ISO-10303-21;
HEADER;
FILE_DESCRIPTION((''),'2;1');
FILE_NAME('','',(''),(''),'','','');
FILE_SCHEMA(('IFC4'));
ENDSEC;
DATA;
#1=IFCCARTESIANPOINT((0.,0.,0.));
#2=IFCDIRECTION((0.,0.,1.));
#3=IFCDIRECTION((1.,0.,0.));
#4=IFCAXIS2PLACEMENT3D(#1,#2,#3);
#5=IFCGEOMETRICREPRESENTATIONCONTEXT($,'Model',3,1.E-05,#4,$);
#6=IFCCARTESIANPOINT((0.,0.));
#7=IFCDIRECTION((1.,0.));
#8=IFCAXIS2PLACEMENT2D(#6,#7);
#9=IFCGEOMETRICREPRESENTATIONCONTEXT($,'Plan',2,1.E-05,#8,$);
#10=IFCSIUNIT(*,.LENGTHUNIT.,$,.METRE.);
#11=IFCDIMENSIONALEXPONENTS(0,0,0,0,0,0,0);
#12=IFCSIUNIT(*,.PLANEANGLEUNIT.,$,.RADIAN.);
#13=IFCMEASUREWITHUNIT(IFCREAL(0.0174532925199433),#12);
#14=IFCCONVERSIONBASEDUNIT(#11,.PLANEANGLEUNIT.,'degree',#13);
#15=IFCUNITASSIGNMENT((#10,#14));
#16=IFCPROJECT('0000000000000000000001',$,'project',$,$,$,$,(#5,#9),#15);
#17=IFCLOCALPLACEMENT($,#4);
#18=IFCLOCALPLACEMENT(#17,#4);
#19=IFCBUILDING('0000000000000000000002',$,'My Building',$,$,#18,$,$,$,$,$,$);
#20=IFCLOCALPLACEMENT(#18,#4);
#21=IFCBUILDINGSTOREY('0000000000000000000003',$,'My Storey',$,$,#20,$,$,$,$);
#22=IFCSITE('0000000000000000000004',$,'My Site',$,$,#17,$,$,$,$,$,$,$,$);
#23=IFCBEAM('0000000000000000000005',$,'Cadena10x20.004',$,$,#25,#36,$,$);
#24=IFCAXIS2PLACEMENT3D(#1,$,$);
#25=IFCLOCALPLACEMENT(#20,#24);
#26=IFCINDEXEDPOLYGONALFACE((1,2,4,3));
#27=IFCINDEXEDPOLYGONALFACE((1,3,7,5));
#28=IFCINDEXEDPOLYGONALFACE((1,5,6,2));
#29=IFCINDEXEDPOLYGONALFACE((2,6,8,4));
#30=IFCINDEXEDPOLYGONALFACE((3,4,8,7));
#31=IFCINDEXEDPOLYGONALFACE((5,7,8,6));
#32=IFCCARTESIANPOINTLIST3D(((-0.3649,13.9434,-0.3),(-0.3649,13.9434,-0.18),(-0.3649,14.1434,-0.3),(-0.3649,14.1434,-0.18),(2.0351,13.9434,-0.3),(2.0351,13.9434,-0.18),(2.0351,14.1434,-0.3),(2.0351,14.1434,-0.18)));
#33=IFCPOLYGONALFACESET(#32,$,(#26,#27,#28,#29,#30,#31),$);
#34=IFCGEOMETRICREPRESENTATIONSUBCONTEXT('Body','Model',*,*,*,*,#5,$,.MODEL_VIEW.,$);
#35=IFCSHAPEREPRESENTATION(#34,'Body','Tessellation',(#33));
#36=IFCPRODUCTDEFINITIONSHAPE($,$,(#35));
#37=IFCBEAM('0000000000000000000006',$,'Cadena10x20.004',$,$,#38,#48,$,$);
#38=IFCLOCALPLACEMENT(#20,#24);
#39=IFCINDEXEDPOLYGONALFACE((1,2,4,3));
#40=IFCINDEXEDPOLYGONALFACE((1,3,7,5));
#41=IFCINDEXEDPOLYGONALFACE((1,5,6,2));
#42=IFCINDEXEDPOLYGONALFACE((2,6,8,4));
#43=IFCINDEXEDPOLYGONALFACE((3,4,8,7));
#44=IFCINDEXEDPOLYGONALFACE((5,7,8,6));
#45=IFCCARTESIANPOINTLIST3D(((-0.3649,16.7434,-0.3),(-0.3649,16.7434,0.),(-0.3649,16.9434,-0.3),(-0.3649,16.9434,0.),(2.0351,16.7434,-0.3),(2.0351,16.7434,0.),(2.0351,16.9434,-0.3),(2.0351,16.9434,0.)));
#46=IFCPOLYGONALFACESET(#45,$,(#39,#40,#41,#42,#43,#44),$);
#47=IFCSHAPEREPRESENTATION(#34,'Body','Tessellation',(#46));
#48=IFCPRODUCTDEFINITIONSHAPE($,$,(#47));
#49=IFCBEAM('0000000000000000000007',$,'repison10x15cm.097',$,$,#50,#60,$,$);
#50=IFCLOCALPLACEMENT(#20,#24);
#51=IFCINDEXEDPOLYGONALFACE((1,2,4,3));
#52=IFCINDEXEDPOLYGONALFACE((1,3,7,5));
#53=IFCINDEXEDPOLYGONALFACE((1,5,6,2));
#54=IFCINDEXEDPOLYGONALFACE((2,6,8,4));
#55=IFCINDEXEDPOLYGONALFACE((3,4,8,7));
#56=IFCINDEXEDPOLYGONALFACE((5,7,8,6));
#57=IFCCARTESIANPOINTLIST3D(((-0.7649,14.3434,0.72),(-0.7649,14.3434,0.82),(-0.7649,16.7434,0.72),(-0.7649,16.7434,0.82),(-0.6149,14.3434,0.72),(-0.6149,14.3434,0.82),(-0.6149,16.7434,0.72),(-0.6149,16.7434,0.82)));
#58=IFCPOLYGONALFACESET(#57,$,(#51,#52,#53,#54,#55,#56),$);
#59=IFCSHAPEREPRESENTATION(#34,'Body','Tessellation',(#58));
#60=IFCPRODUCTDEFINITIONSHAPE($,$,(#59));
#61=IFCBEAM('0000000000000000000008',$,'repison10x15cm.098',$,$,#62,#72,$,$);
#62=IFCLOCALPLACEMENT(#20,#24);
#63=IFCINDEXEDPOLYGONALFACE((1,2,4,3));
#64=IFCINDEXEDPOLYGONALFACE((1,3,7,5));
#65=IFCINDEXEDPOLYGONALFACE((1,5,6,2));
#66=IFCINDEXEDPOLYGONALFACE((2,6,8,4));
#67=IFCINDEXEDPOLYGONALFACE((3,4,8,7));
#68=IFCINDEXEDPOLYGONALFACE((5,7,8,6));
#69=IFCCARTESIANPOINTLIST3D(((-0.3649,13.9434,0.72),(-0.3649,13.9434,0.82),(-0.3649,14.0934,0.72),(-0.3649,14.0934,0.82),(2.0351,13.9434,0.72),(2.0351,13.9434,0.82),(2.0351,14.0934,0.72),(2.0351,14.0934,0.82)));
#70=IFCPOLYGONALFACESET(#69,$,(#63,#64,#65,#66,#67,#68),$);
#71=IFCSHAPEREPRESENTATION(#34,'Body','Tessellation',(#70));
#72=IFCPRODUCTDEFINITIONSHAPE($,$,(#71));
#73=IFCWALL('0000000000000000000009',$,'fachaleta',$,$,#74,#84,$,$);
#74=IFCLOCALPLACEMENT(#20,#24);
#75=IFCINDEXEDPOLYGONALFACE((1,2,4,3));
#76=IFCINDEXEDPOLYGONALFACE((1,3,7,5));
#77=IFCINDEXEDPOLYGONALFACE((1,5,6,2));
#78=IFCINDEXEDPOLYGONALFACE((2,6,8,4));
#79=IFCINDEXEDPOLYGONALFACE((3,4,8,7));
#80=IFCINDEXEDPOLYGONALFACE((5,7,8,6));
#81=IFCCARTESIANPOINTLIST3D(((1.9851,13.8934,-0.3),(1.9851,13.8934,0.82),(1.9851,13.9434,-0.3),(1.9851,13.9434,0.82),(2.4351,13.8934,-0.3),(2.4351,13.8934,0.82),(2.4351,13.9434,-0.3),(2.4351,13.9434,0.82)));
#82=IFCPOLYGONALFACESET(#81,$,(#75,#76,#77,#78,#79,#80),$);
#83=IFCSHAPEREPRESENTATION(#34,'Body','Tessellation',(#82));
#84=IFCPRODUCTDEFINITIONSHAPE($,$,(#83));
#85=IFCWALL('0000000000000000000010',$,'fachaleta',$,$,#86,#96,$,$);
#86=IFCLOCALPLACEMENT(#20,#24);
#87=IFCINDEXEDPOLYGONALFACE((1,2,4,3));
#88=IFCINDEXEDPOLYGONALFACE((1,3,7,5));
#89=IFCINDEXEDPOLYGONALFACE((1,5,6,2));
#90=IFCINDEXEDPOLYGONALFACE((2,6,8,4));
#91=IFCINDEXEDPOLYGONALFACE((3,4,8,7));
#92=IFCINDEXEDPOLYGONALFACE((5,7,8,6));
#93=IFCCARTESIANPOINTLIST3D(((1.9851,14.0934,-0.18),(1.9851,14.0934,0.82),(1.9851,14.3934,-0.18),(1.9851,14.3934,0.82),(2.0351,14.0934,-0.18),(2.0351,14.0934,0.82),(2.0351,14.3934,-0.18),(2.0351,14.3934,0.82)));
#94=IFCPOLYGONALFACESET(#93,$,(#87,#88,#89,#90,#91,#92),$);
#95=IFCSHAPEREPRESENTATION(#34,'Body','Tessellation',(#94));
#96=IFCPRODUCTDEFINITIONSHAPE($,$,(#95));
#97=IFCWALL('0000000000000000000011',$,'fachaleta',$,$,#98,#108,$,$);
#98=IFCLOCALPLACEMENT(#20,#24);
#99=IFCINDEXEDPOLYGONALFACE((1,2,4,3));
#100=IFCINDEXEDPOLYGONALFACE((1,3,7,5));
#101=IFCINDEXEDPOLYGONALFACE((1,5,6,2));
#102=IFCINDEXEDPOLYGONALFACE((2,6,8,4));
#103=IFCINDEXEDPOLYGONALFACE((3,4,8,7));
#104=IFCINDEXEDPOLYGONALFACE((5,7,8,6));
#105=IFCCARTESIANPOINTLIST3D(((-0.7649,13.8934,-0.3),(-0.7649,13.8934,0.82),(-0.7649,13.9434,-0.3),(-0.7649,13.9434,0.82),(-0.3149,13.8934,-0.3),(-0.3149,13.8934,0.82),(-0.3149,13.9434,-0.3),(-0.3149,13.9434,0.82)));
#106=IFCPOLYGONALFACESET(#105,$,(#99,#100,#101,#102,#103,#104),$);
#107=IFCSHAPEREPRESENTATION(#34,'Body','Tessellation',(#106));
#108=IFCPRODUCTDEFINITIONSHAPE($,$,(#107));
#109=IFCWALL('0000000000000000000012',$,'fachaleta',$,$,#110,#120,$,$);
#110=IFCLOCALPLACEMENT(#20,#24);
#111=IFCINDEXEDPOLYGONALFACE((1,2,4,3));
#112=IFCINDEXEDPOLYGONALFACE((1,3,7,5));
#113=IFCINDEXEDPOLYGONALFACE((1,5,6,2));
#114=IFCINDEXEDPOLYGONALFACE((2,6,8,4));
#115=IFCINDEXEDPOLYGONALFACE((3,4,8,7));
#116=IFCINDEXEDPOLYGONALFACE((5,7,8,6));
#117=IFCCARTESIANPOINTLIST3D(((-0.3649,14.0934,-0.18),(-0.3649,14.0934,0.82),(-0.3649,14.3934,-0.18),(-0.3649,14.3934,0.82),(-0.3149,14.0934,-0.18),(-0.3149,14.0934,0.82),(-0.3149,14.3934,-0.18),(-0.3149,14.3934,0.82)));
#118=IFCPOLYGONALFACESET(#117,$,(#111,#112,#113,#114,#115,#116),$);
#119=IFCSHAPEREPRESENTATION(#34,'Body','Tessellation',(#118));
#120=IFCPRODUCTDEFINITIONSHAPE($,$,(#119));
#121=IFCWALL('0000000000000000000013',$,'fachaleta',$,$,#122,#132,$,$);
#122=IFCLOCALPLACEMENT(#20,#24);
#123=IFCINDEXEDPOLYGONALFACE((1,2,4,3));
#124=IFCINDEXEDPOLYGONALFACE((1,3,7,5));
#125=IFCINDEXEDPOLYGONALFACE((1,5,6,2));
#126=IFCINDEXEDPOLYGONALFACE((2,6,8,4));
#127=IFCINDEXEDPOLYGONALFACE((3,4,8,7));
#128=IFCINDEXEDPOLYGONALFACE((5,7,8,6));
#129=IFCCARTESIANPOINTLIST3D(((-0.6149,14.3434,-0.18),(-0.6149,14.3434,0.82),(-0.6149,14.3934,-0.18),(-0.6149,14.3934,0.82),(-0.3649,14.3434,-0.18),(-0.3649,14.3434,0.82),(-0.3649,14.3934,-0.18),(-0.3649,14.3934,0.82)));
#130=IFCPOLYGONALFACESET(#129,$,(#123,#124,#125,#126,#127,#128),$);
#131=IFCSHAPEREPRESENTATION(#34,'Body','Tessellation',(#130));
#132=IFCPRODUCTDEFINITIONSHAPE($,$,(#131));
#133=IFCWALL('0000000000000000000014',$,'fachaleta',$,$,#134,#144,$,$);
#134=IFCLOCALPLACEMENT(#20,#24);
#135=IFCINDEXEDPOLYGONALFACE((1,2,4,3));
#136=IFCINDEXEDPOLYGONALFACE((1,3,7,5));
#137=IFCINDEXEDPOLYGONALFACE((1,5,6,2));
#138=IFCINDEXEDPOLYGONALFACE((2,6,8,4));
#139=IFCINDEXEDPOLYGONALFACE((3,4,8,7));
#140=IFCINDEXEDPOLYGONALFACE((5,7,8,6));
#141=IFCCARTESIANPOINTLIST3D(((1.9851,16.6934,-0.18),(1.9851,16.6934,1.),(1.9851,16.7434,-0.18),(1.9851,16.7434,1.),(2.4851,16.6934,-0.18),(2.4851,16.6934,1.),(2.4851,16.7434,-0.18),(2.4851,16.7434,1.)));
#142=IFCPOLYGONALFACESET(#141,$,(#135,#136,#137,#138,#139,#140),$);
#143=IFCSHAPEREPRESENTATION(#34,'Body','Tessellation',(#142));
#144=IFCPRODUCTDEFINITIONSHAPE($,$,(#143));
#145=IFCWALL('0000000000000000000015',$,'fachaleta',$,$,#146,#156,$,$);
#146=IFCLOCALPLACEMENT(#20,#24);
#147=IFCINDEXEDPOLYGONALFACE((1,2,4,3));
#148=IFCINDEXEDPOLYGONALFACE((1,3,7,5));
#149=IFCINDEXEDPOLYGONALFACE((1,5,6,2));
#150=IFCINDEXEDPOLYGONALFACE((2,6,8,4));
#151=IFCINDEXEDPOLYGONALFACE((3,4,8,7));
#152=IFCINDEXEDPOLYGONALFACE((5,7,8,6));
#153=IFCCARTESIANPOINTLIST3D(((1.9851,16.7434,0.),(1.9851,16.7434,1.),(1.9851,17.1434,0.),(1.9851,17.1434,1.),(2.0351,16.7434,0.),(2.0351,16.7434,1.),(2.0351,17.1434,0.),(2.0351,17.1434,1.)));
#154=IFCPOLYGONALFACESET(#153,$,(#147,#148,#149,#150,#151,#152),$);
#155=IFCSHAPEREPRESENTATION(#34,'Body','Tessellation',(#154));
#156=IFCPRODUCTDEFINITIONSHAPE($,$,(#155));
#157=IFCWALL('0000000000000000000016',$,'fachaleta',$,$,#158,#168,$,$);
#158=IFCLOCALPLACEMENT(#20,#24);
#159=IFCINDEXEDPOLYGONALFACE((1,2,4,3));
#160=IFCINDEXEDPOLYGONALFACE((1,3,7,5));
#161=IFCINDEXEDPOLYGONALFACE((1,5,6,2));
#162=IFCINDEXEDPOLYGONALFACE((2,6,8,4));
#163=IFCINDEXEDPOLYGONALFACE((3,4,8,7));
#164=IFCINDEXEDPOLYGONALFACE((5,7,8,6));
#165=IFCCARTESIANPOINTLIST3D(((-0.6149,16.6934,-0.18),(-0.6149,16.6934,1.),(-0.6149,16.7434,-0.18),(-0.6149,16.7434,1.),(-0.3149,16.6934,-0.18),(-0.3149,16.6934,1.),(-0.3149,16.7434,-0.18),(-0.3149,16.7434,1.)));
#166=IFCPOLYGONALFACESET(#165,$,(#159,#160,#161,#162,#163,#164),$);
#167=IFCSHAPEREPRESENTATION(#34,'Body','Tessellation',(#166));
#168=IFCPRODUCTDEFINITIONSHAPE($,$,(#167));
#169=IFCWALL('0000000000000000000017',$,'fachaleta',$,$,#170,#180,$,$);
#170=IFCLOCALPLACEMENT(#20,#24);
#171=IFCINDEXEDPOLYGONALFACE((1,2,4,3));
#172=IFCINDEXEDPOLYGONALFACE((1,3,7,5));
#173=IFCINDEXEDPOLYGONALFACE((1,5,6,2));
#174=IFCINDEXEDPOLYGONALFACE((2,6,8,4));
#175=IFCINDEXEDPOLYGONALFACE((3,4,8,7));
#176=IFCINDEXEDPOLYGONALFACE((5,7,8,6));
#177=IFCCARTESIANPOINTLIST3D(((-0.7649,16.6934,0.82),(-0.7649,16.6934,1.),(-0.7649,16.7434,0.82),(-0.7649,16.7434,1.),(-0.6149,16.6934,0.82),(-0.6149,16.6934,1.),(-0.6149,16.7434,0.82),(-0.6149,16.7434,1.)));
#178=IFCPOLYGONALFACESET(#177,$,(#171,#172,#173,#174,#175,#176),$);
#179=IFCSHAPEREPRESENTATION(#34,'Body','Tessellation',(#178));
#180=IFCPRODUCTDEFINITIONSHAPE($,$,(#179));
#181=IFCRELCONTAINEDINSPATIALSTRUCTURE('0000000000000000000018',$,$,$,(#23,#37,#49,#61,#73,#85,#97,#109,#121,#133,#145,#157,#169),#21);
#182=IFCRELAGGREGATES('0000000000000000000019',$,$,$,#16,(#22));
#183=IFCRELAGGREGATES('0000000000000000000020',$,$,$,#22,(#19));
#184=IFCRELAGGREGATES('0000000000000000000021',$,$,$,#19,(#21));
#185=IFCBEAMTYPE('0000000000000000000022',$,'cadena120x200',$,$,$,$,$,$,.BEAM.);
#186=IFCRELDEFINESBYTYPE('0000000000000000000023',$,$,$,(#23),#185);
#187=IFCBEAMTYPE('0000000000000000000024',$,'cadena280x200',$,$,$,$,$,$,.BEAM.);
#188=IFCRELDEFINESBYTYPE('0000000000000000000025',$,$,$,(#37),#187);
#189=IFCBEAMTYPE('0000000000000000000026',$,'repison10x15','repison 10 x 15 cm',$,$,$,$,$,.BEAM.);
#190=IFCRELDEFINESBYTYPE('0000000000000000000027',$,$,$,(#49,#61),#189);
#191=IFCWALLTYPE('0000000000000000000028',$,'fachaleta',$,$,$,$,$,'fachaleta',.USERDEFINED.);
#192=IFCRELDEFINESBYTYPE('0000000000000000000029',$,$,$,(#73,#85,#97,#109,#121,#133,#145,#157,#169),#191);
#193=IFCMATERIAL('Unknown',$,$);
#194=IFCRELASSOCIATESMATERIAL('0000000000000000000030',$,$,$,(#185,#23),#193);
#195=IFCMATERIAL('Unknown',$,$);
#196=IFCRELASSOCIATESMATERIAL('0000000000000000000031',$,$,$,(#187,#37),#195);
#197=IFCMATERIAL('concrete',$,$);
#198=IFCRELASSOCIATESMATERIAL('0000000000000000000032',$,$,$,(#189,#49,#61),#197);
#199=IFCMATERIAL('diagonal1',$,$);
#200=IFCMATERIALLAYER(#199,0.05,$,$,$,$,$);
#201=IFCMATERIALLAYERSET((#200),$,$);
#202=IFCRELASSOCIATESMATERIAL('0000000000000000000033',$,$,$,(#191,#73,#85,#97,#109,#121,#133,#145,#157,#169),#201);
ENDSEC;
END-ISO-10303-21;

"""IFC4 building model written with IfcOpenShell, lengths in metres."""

from ifc_helpers import new_model, entity, si_unit, converted_unit, frame, origin_with_axes, origin_2d_with_axis, place, context, subcontext, project, spatial, indexed_curve, rectangle, outline, extrude, material, layer, layer_set, layer_usage, material_profile, profile_set, profile_usage, type_object, element, save


model = new_model("IFC4")

# Units and contexts
model_context = context("Model", 3, precision=1e-05, world=origin_with_axes())
plan_context = context("Plan", 2, precision=1e-05, world=origin_2d_with_axis())
body_context = subcontext(model_context, "Body", "Model", "MODEL_VIEW")
ifc_project = project(units=[si_unit("LENGTHUNIT", "METRE"), converted_unit("PLANEANGLEUNIT", "degree", entity("IfcReal", 0.0174532925199433), si_unit("PLANEANGLEUNIT", "RADIAN"), dimensions=[0, 0, 0, 0, 0, 0, 0])], contexts=[model_context, plan_context])

# Site, building, storey
site_placement = place(None, origin_with_axes())
site = spatial("IfcSite", under=ifc_project, at=site_placement, Name="My Site")
building_placement = place(site_placement, origin_with_axes())
building = spatial("IfcBuilding", under=site, at=building_placement, Name="My Building")
storey_placement = place(building_placement, origin_with_axes())
storey = spatial("IfcBuildingStorey", under=building, at=storey_placement, Name="My Storey")

# Shared definitions
ifc_material_1 = material(Name="concrete")

# Beams
ifc_material_2 = material(Name="Unknown")
ifc_material_profile_1 = material_profile(ifc_material_2, rectangle(XDim=0.2, YDim=0.12))
ifc_profile_set_1 = profile_set([ifc_material_profile_1], Name="concrete")
beam_type_1 = type_object("IfcBeamType", Name="cadena120x200", PredefinedType="BEAM", material=ifc_profile_set_1)
ifc_profile_usage_1 = profile_usage(ifc_profile_set_1, cardinal=5)
beam_1_placement = place(storey_placement, frame((-0.3649, 14.0434, -0.24), z_axis=(1.0, -0.000001, 0.0), x_axis=(0.000001, 1.0, 0.0)))
element("IfcBeam", 1, at=beam_1_placement, inside=storey, type_object=beam_type_1, material=ifc_profile_usage_1, Name="Cadena10x20.004", context=body_context, shape_type="SweptSolid", body=[
    extrude(rectangle(XDim=0.2, YDim=0.12), origin_with_axes(), (0.0, 0.0, 1.0), 2.4),
])
ifc_material_3 = material(Name="Unknown")
ifc_material_profile_2 = material_profile(ifc_material_3, rectangle(XDim=0.2, YDim=0.3))
ifc_profile_set_2 = profile_set([ifc_material_profile_2], Name="concrete")
ifc_profile_usage_2 = profile_usage(ifc_profile_set_2)
beam_type_2 = type_object("IfcBeamType", Name="cadena280x200", PredefinedType="BEAM", material=ifc_profile_set_2)
beam_2_placement = place(storey_placement, frame((-0.3649, 16.8434, -0.15), z_axis=(1.0, -0.000001, 0.000001), x_axis=(0.000001, 1.0, 0.0)))
element("IfcBeam", 2, at=beam_2_placement, inside=storey, type_object=beam_type_2, material=ifc_profile_usage_2, Name="Cadena10x20.004", context=body_context, shape_type="SweptSolid", body=[
    extrude(rectangle(XDim=0.2, YDim=0.3), origin_with_axes(), (0.0, 0.0, 1.0), 2.4),
])
ifc_material_profile_3 = material_profile(ifc_material_1, rectangle(XDim=0.15, YDim=0.1))
ifc_profile_set_3 = profile_set([ifc_material_profile_3])
ifc_profile_usage_3 = profile_usage(ifc_profile_set_3, cardinal=5)
beam_type_3 = type_object("IfcBeamType", Name="repison10x15", Description="repison 10 x 15 cm", PredefinedType="BEAM", material=ifc_profile_set_3)
beam_3_placement = place(storey_placement, frame((-0.6899, 14.3434, 0.77), z_axis=(0.0, 1.0, 0.0), x_axis=(-1.0, 0.0, 0.0)))
element("IfcBeam", 3, at=beam_3_placement, inside=storey, type_object=beam_type_3, material=ifc_profile_usage_3, Name="repison10x15cm.097", context=body_context, shape_type="SweptSolid", body=[
    extrude(rectangle(XDim=0.15, YDim=0.1), origin_with_axes(), (0.0, 0.0, 1.0), 2.4),
])
ifc_profile_usage_4 = profile_usage(ifc_profile_set_3, cardinal=5)
beam_4_placement = place(storey_placement, frame((-0.3649, 14.0184, 0.77), z_axis=(1.0, 0.0, 0.0), x_axis=(0.0, 1.0, 0.0)))
element("IfcBeam", 4, at=beam_4_placement, inside=storey, type_object=beam_type_3, material=ifc_profile_usage_4, Name="repison10x15cm.098", context=body_context, shape_type="SweptSolid", body=[
    extrude(rectangle(XDim=0.15, YDim=0.1), origin_with_axes(), (0.0, 0.0, 1.0), 2.4),
])

# Walls
ifc_material_4 = material(Name="diagonal1")
ifc_layer_1 = layer(ifc_material_4, 0.05)
ifc_layer_set_1 = layer_set([ifc_layer_1])
ifc_layer_usage_1 = layer_usage(ifc_layer_set_1, "AXIS2", "POSITIVE", 0.0)
wall_type_1 = type_object("IfcWallType", Name="fachaleta", ElementType="fachaleta", PredefinedType="USERDEFINED", material=ifc_layer_set_1)
wall_1_placement = place(storey_placement, frame((1.9851, 13.8934, -0.3), z_axis=(0.0, 0.0, 1.0), x_axis=(1.0, 0.0, 0.0)))
element("IfcWall", 5, at=wall_1_placement, inside=storey, type_object=wall_type_1, material=ifc_layer_usage_1, Name="fachaleta", context=body_context, shape_type="SweptSolid", body=[
    extrude(outline(indexed_curve([(0.0, 0.0), (0.0, 0.05), (0.45, 0.05), (0.45, 0.0), (0.0, 0.0)], self_intersect=False)), origin_with_axes(), (0.0, 0.0, 1.0), 1.12),
])
ifc_layer_usage_2 = layer_usage(ifc_layer_set_1, "AXIS2", "POSITIVE", 0.0)
wall_2_placement = place(storey_placement, frame((1.9851, 14.3934, -0.18), z_axis=(0.0, 0.0, 1.0), x_axis=(0.0, -1.0, 0.0)))
element("IfcWall", 6, at=wall_2_placement, inside=storey, type_object=wall_type_1, material=ifc_layer_usage_2, Name="fachaleta", context=body_context, shape_type="SweptSolid", body=[
    extrude(outline(indexed_curve([(0.0, 0.0), (0.0, 0.05), (0.3, 0.05), (0.3, 0.0), (0.0, 0.0)], self_intersect=False)), origin_with_axes(), (0.0, 0.0, 1.0), 1.0),
])
ifc_layer_usage_3 = layer_usage(ifc_layer_set_1, "AXIS2", "POSITIVE", 0.0)
wall_3_placement = place(storey_placement, frame((-0.7649, 13.8934, -0.3), z_axis=(0.0, 0.0, 1.0), x_axis=(1.0, 0.0, 0.0)))
element("IfcWall", 7, at=wall_3_placement, inside=storey, type_object=wall_type_1, material=ifc_layer_usage_3, Name="fachaleta", context=body_context, shape_type="SweptSolid", body=[
    extrude(outline(indexed_curve([(0.0, 0.0), (0.0, 0.05), (0.45, 0.05), (0.45, 0.0), (0.0, 0.0)], self_intersect=False)), origin_with_axes(), (0.0, 0.0, 1.0), 1.12),
])
ifc_layer_usage_4 = layer_usage(ifc_layer_set_1, "AXIS2", "POSITIVE", 0.0)
wall_4_placement = place(storey_placement, frame((-0.3649, 14.3934, -0.18), z_axis=(0.0, 0.0, 1.0), x_axis=(0.0, -1.0, 0.0)))
element("IfcWall", 8, at=wall_4_placement, inside=storey, type_object=wall_type_1, material=ifc_layer_usage_4, Name="fachaleta", context=body_context, shape_type="SweptSolid", body=[
    extrude(outline(indexed_curve([(0.0, 0.0), (0.0, 0.05), (0.3, 0.05), (0.3, 0.0), (0.0, 0.0)], self_intersect=False)), origin_with_axes(), (0.0, 0.0, 1.0), 1.0),
])
ifc_layer_usage_5 = layer_usage(ifc_layer_set_1, "AXIS2", "POSITIVE", 0.0)
wall_5_placement = place(storey_placement, frame((-0.6149, 14.3434, -0.18), z_axis=(0.0, 0.0, 1.0), x_axis=(1.0, 0.0, 0.0)))
element("IfcWall", 9, at=wall_5_placement, inside=storey, type_object=wall_type_1, material=ifc_layer_usage_5, Name="fachaleta", context=body_context, shape_type="SweptSolid", body=[
    extrude(outline(indexed_curve([(0.0, 0.0), (0.0, 0.05), (0.25, 0.05), (0.25, 0.0), (0.0, 0.0)], self_intersect=False)), origin_with_axes(), (0.0, 0.0, 1.0), 1.0),
])
ifc_layer_usage_6 = layer_usage(ifc_layer_set_1, "AXIS2", "POSITIVE", 0.0)
wall_6_placement = place(storey_placement, frame((1.9851, 16.6934, -0.18), z_axis=(0.0, 0.0, 1.0), x_axis=(1.0, 0.0, 0.0)))
element("IfcWall", 10, at=wall_6_placement, inside=storey, type_object=wall_type_1, material=ifc_layer_usage_6, Name="fachaleta", context=body_context, shape_type="SweptSolid", body=[
    extrude(outline(indexed_curve([(0.0, 0.0), (0.0, 0.05), (0.5, 0.05), (0.5, 0.0), (0.0, 0.0)], self_intersect=False)), origin_with_axes(), (0.0, 0.0, 1.0), 1.18),
])
ifc_layer_usage_7 = layer_usage(ifc_layer_set_1, "AXIS2", "POSITIVE", 0.0)
wall_7_placement = place(storey_placement, frame((2.0351, 16.7434, 0.0), z_axis=(0.0, 0.0, 1.0), x_axis=(0.0, 1.0, 0.0)))
element("IfcWall", 11, at=wall_7_placement, inside=storey, type_object=wall_type_1, material=ifc_layer_usage_7, Name="fachaleta", context=body_context, shape_type="SweptSolid", body=[
    extrude(outline(indexed_curve([(0.0, 0.0), (0.0, 0.05), (0.4, 0.05), (0.4, 0.0), (0.0, 0.0)], self_intersect=False)), origin_with_axes(), (0.0, 0.0, 1.0), 1.0),
])
ifc_layer_usage_8 = layer_usage(ifc_layer_set_1, "AXIS2", "POSITIVE", 0.0)
wall_8_placement = place(storey_placement, frame((-0.6149, 16.6934, -0.18), z_axis=(0.0, 0.0, 1.0), x_axis=(1.0, 0.0, 0.0)))
element("IfcWall", 12, at=wall_8_placement, inside=storey, type_object=wall_type_1, material=ifc_layer_usage_8, Name="fachaleta", context=body_context, shape_type="SweptSolid", body=[
    extrude(outline(indexed_curve([(0.0, 0.0), (0.0, 0.05), (0.3, 0.05), (0.3, 0.0), (0.0, 0.0)], self_intersect=False)), origin_with_axes(), (0.0, 0.0, 1.0), 1.18),
])
ifc_layer_usage_9 = layer_usage(ifc_layer_set_1, "AXIS2", "POSITIVE", 0.0)
wall_9_placement = place(storey_placement, frame((-0.7649, 16.6934, 0.82), z_axis=(0.0, 0.0, 1.0), x_axis=(1.0, 0.0, 0.0)))
element("IfcWall", 13, at=wall_9_placement, inside=storey, type_object=wall_type_1, material=ifc_layer_usage_9, Name="fachaleta", context=body_context, shape_type="SweptSolid", body=[
    extrude(outline(indexed_curve([(0.0, 0.0), (0.0, 0.05), (0.15, 0.05), (0.15, 0.0), (0.0, 0.0)], self_intersect=False)), origin_with_axes(), (0.0, 0.0, 1.0), 0.18),
])

save(model, "model.ifc")
